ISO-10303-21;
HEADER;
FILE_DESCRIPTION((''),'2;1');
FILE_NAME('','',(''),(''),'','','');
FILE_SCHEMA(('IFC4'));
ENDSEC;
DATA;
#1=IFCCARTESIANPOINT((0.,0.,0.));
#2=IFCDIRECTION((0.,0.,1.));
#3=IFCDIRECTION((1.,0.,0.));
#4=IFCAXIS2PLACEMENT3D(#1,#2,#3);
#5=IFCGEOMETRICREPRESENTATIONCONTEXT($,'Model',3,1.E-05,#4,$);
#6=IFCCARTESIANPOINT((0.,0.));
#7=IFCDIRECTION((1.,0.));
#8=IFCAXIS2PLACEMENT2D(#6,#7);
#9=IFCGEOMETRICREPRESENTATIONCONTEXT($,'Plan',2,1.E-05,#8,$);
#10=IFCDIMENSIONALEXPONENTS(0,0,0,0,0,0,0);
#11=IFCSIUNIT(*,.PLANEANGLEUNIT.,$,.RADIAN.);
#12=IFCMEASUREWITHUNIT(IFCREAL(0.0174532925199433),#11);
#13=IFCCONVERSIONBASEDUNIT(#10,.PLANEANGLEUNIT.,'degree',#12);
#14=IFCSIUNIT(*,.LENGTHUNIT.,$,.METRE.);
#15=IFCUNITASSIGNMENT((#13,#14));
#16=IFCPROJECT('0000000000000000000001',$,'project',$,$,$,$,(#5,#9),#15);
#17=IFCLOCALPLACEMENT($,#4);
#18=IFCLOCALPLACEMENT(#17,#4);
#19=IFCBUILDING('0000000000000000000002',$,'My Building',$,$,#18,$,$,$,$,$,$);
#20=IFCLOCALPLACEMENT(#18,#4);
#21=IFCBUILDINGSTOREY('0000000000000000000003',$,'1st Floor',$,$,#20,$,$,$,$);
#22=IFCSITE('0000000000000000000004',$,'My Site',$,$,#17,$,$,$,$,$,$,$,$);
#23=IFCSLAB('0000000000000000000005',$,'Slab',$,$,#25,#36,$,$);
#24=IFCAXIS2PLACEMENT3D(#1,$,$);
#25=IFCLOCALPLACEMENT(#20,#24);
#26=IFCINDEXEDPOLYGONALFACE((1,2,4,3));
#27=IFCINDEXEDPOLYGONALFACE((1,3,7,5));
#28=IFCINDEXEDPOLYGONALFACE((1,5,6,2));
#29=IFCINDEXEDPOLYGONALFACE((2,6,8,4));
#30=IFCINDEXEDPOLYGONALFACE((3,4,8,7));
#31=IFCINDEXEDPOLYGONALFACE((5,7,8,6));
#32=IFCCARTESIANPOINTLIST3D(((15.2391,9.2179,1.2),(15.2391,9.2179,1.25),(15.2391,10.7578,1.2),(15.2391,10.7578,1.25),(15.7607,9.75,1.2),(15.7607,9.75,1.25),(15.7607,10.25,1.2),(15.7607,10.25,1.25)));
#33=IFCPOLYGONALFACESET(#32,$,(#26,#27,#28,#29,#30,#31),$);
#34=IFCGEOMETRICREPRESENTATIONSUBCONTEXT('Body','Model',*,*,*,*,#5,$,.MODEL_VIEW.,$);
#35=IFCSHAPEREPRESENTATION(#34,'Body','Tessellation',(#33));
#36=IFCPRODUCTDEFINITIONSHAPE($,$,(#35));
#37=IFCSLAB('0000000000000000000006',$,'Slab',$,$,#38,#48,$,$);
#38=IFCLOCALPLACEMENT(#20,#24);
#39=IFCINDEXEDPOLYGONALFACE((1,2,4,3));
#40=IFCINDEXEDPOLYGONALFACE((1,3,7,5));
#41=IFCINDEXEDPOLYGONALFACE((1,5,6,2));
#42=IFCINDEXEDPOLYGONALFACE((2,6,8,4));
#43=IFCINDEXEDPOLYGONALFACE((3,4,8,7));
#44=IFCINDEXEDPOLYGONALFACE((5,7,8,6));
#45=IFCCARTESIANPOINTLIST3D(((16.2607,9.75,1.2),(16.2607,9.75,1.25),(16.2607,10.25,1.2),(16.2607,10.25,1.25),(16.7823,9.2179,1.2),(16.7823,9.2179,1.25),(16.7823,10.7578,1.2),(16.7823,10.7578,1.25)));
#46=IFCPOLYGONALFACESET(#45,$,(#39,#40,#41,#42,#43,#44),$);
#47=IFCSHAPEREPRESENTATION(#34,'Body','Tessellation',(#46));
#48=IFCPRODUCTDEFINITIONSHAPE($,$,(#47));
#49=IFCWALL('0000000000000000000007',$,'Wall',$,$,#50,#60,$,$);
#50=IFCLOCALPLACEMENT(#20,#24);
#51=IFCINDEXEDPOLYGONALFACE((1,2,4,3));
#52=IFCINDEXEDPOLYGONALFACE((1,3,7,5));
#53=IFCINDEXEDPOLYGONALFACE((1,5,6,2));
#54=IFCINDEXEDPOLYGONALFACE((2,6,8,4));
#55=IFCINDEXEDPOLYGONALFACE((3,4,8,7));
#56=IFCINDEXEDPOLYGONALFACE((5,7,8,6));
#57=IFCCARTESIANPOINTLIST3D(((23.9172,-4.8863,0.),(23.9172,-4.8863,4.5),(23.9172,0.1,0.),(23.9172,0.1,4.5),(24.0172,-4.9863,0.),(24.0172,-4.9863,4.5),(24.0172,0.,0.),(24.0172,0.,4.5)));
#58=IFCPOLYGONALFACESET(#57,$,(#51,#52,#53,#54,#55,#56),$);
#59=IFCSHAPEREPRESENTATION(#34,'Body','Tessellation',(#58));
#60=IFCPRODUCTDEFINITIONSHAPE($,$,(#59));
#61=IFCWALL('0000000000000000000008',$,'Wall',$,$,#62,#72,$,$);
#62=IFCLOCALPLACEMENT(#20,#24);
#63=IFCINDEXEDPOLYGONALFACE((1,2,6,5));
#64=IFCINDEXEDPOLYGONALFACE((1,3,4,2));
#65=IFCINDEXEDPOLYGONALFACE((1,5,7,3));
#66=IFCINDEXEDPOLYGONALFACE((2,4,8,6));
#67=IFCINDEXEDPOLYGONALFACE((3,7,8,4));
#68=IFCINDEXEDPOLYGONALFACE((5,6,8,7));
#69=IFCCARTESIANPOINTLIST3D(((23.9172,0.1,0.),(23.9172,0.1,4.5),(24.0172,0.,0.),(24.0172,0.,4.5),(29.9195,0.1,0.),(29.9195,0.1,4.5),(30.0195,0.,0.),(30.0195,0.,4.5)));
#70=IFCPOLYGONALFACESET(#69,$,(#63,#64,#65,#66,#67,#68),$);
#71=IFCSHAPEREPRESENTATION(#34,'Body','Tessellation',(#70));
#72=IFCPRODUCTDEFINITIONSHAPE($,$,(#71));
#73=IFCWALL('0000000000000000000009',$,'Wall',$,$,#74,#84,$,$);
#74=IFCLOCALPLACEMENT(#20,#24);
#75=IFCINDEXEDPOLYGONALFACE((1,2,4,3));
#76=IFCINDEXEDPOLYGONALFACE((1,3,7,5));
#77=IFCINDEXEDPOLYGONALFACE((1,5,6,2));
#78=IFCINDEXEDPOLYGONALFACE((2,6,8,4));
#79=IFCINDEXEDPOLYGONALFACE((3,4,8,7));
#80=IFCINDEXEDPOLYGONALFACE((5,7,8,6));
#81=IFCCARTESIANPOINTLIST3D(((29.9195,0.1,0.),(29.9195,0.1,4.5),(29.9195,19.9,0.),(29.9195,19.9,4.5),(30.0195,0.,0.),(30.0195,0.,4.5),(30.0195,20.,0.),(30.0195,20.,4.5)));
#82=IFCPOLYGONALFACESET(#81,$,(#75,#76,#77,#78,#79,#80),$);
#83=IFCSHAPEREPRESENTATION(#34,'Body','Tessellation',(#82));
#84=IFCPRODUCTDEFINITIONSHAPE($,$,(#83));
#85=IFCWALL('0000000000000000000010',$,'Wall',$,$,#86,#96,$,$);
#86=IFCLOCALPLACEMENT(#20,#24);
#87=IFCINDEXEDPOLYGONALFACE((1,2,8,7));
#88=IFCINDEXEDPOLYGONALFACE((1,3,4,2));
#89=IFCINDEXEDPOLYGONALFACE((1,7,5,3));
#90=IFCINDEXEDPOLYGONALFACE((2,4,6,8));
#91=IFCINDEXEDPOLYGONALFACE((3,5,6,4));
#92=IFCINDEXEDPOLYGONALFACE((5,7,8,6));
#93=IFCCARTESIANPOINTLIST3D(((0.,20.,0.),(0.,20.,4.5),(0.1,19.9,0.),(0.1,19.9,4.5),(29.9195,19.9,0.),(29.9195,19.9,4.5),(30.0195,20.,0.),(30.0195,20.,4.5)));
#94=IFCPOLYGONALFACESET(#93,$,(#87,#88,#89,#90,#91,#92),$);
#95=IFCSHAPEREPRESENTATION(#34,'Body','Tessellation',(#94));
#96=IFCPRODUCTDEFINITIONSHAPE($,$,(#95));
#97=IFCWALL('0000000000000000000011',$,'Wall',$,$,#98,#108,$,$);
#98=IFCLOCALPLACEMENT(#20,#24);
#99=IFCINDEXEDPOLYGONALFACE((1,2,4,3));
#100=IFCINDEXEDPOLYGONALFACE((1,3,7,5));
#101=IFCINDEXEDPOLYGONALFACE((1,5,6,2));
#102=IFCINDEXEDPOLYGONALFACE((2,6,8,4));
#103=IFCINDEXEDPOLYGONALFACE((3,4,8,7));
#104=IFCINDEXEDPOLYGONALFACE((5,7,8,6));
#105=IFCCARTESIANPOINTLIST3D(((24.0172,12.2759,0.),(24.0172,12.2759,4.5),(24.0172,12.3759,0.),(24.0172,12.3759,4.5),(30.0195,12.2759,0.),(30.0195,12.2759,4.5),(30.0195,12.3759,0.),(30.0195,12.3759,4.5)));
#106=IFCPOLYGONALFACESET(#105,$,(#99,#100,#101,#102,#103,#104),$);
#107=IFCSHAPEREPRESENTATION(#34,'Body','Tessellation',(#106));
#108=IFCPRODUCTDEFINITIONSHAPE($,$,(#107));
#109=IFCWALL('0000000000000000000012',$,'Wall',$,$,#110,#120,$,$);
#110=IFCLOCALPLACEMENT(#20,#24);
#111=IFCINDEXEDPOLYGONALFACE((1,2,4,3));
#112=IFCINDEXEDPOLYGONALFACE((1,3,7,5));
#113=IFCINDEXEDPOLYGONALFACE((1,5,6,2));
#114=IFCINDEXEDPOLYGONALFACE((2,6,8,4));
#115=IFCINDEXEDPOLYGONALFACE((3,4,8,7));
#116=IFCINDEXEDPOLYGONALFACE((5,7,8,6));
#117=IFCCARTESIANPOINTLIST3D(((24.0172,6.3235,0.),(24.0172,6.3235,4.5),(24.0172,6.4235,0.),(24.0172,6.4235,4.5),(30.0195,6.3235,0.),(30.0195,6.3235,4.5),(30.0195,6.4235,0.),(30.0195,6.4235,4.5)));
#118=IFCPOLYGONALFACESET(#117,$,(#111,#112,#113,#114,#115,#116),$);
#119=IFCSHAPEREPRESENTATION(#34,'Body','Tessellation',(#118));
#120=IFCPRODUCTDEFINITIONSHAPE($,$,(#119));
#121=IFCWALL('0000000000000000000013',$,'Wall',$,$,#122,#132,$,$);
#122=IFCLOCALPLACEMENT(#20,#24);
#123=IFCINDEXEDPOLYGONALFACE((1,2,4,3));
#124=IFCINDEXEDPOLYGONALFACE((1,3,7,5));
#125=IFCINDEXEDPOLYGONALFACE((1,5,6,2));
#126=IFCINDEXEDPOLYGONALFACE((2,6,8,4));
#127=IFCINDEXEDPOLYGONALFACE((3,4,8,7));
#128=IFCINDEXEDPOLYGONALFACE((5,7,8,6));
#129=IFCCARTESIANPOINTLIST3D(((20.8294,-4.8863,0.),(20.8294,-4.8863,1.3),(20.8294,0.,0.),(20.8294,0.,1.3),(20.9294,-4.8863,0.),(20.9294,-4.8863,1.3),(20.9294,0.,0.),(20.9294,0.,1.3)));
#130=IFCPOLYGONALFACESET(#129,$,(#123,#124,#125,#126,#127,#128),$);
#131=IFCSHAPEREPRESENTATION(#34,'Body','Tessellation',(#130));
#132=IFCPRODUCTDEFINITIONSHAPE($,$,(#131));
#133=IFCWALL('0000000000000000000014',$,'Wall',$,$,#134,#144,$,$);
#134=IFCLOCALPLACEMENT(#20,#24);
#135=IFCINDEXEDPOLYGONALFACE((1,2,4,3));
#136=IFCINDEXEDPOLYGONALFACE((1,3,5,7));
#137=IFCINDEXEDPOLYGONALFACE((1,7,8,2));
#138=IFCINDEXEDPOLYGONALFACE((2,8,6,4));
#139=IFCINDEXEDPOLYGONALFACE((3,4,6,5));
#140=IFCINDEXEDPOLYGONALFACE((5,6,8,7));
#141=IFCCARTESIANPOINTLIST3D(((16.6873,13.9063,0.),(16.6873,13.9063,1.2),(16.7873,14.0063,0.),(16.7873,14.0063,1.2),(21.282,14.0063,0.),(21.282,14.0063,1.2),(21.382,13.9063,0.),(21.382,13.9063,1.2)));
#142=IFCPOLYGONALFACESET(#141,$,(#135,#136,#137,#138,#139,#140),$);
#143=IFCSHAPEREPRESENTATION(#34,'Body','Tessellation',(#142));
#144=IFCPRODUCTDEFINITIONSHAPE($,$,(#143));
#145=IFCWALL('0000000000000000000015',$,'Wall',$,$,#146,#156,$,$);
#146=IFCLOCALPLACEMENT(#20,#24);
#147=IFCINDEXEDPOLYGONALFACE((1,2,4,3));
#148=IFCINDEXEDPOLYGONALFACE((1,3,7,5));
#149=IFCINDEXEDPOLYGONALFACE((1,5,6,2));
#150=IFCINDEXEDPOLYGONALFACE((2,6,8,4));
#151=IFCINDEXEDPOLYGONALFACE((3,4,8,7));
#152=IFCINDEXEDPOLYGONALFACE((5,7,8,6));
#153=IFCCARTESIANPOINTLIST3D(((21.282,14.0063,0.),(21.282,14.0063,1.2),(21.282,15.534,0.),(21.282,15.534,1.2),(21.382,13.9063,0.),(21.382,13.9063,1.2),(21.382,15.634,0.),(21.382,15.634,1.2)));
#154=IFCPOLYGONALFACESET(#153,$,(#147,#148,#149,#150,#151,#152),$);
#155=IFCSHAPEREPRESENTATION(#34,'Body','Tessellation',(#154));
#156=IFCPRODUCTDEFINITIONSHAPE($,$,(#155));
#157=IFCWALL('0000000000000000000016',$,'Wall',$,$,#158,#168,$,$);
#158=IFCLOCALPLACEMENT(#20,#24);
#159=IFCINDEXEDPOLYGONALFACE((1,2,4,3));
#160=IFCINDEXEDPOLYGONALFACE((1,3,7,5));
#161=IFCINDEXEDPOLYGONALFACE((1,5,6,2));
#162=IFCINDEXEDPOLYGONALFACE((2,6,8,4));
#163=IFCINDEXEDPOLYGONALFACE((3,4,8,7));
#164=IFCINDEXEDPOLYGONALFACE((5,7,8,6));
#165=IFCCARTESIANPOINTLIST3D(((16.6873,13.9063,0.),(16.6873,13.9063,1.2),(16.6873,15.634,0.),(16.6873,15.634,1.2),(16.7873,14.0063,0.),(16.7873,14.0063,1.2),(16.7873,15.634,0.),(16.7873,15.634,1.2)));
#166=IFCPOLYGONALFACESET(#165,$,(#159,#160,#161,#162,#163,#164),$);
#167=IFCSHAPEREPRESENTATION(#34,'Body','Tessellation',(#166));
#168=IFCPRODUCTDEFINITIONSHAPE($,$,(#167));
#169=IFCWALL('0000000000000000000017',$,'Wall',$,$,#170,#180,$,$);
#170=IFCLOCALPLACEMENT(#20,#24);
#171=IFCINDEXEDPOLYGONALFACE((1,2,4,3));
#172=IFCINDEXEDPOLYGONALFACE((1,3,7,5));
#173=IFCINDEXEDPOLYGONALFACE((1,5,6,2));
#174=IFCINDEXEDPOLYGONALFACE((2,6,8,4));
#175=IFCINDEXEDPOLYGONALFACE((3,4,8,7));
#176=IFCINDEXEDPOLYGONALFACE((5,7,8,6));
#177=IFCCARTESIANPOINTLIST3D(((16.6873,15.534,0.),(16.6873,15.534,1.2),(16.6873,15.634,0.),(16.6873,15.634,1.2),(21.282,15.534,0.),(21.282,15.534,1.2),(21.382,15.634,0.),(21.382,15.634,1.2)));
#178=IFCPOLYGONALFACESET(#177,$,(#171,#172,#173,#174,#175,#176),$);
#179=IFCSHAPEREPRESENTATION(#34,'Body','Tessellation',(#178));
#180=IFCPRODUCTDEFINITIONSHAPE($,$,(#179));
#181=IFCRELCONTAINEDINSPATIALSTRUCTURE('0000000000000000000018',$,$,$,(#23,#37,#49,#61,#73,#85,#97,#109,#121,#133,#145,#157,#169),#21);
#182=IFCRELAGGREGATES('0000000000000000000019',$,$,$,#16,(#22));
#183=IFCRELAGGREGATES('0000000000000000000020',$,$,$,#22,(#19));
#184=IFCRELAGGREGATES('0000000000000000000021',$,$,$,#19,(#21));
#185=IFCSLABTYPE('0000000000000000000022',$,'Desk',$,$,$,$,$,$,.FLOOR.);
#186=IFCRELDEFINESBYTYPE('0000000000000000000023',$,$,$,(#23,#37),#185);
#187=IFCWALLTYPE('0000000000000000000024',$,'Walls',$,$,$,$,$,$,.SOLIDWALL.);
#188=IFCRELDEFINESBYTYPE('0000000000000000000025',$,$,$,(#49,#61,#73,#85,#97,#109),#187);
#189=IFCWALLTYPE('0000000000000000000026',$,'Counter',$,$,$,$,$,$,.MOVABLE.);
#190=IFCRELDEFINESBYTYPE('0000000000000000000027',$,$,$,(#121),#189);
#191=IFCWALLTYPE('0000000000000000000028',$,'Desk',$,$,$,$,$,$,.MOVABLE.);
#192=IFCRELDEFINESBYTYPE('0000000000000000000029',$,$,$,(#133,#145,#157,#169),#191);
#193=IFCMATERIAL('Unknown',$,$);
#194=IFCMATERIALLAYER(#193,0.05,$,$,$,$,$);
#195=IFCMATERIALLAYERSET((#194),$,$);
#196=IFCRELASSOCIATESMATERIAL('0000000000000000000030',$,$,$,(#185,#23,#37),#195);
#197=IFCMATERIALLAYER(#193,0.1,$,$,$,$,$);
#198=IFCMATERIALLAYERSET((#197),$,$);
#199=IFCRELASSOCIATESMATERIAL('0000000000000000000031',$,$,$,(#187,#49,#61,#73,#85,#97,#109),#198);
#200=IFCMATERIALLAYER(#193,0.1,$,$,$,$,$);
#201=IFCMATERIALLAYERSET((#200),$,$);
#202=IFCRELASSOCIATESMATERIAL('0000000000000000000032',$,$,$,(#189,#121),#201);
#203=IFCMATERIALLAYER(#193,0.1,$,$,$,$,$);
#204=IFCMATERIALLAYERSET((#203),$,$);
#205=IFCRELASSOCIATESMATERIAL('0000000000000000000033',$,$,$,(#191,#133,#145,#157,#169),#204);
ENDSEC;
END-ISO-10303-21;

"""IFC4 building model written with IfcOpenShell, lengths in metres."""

from ifc_helpers import new_model, entity, si_unit, converted_unit, frame, origin_with_axes, origin_2d_with_axis, place, context, subcontext, project, spatial, line, indexed_curve, outline, extrude, material, layer, layer_set, layer_usage, type_object, element, save


model = new_model("IFC4")

# Units and contexts
model_context = context("Model", 3, precision=1e-05, world=origin_with_axes())
plan_context = context("Plan", 2, precision=1e-05, world=origin_2d_with_axis())
body_context_1 = subcontext(model_context, "Body", "Model", "MODEL_VIEW")
ifc_project = project(units=[converted_unit("PLANEANGLEUNIT", "degree", entity("IfcReal", 0.0174532925199433), si_unit("PLANEANGLEUNIT", "RADIAN"), dimensions=[0, 0, 0, 0, 0, 0, 0]), si_unit("LENGTHUNIT", "METRE")], contexts=[model_context, plan_context])

# Site, building, storey
site_placement = place(None, origin_with_axes())
site = spatial("IfcSite", under=ifc_project, at=site_placement, Name="My Site")
building_placement = place(site_placement, origin_with_axes())
building = spatial("IfcBuilding", under=site, at=building_placement, Name="My Building")
storey_placement = place(building_placement, origin_with_axes())
storey = spatial("IfcBuildingStorey", under=building, at=storey_placement, Name="1st Floor")

# Shared definitions
ifc_material = material(Name="Unknown")

# Slabs
ifc_layer_1 = layer(ifc_material, 0.05)
ifc_layer_set_1 = layer_set([ifc_layer_1])
slab_type_1 = type_object("IfcSlabType", Name="Desk", PredefinedType="FLOOR", material=ifc_layer_set_1)
ifc_layer_usage_1 = layer_usage(ifc_layer_set_1, "AXIS3", "POSITIVE", -0.05)
slab_1_placement = place(storey_placement, frame((15.7607, 10.25, 1.25), z_axis=(0.0, 0.0, 1.0), x_axis=(1.0, 0.0, 0.0)))
element("IfcSlab", 1, at=slab_1_placement, inside=storey, type_object=slab_type_1, material=ifc_layer_usage_1, Name="Slab", context=body_context_1, shape_type="SweptSolid", body=[
    extrude(outline(indexed_curve([(0.0, 0.0), (-0.5216, 0.5078), (-0.5216, -1.0321), (0.0, -0.5), (0.0, 0.0)])), frame((0.0, 0.0, -0.05), z_axis=(0.0, 0.0, 1.0), x_axis=(1.0, 0.0, 0.0)), (0.0, 0.0, 1.0), 0.05),
])
ifc_layer_usage_2 = layer_usage(ifc_layer_set_1, "AXIS3", "POSITIVE", -0.05)
slab_2_placement = place(storey_placement, frame((16.7823, 10.7578, 1.25), z_axis=(0.0, 0.0, 1.0), x_axis=(1.0, 0.0, 0.0)))
element("IfcSlab", 2, at=slab_2_placement, inside=storey, type_object=slab_type_1, material=ifc_layer_usage_2, Name="Slab", context=body_context_1, shape_type="SweptSolid", body=[
    extrude(outline(indexed_curve([(0.0, 0.0), (-0.5216, -0.5078), (-0.5216, -1.0078), (0.0, -1.5399), (0.0, 0.0)])), frame((0.0, 0.0, -0.05), z_axis=(0.0, 0.0, 1.0), x_axis=(1.0, 0.0, 0.0)), (0.0, 0.0, 1.0), 0.05),
])

# Walls
ifc_layer_2 = layer(ifc_material, 0.1)
ifc_layer_set_2 = layer_set([ifc_layer_2])
ifc_layer_usage_3 = layer_usage(ifc_layer_set_2, "AXIS2", "POSITIVE", 0.0)
wall_type_1 = type_object("IfcWallType", Name="Walls", PredefinedType="SOLIDWALL", material=ifc_layer_set_2)
wall_1_placement = place(storey_placement, frame((24.0172, -4.9863, 0.0), z_axis=(0.0, 0.0, 1.0), x_axis=(0.0, 1.0, 0.0)))
element("IfcWall", 3, at=wall_1_placement, inside=storey, type_object=wall_type_1, material=ifc_layer_usage_3, Name="Wall", context=body_context_1, shape_type="SweptSolid", body=[
    extrude(outline(indexed_curve([(0.0, 0.0), (0.1, 0.1), (5.0863, 0.1), (4.9863, 0.0)], segments=[line(1, 2, 3, 4, 1)])), origin_with_axes(), (0.0, 0.0, 1.0), 4.5),
])
ifc_layer_usage_4 = layer_usage(ifc_layer_set_2, "AXIS2", "POSITIVE", 0.0)
wall_2_placement = place(storey_placement, frame((24.0172, 0.0, 0.0), z_axis=(0.0, 0.0, 1.0), x_axis=(1.0, 0.0, 0.0)))
element("IfcWall", 4, at=wall_2_placement, inside=storey, type_object=wall_type_1, material=ifc_layer_usage_4, Name="Wall", context=body_context_1, shape_type="SweptSolid", body=[
    extrude(outline(indexed_curve([(0.0, 0.0), (-0.1, 0.1), (5.9023, 0.1), (6.0023, 0.0)], segments=[line(1, 2, 3, 4, 1)])), origin_with_axes(), (0.0, 0.0, 1.0), 4.5),
])
ifc_layer_usage_5 = layer_usage(ifc_layer_set_2, "AXIS2", "POSITIVE", 0.0)
wall_3_placement = place(storey_placement, frame((30.0195, 0.0, 0.0), z_axis=(0.0, 0.0, 1.0), x_axis=(0.0, 1.0, 0.0)))
element("IfcWall", 5, at=wall_3_placement, inside=storey, type_object=wall_type_1, material=ifc_layer_usage_5, Name="Wall", context=body_context_1, shape_type="SweptSolid", body=[
    extrude(outline(indexed_curve([(0.0, 0.0), (0.1, 0.1), (19.9, 0.1), (20.0, 0.0)], segments=[line(1, 2, 3, 4, 1)])), origin_with_axes(), (0.0, 0.0, 1.0), 4.5),
])
ifc_layer_usage_6 = layer_usage(ifc_layer_set_2, "AXIS2", "POSITIVE", 0.0)
wall_4_placement = place(storey_placement, frame((30.0195, 20.0, 0.0), z_axis=(0.0, 0.0, 1.0), x_axis=(-1.0, 0.0, 0.0)))
element("IfcWall", 6, at=wall_4_placement, inside=storey, type_object=wall_type_1, material=ifc_layer_usage_6, Name="Wall", context=body_context_1, shape_type="SweptSolid", body=[
    extrude(outline(indexed_curve([(0.0, 0.0), (0.1, 0.1), (29.9195, 0.1), (30.0195, 0.0)], segments=[line(1, 2, 3, 4, 1)])), origin_with_axes(), (0.0, 0.0, 1.0), 4.5),
])

# Walls
ifc_layer_usage_7 = layer_usage(ifc_layer_set_2, "AXIS2", "POSITIVE", 0.0)
wall_5_placement = place(storey_placement, frame((24.0172, 12.2759, 0.0), z_axis=(0.0, 0.0, 1.0), x_axis=(1.0, 0.0, 0.0)))
element("IfcWall", 7, at=wall_5_placement, inside=storey, type_object=wall_type_1, material=ifc_layer_usage_7, Name="Wall", context=body_context_1, shape_type="SweptSolid", body=[
    extrude(outline(indexed_curve([(0.0, 0.0), (0.0, 0.1), (6.0024, 0.1), (6.0024, 0.0)], segments=[line(1, 2, 3, 4, 1)])), origin_with_axes(), (0.0, 0.0, 1.0), 4.5),
])
ifc_layer_usage_8 = layer_usage(ifc_layer_set_2, "AXIS2", "POSITIVE", 0.0)
wall_6_placement = place(storey_placement, frame((24.0172, 6.3235, 0.0), z_axis=(0.0, 0.0, 1.0), x_axis=(1.0, 0.0, 0.0)))
element("IfcWall", 8, at=wall_6_placement, inside=storey, type_object=wall_type_1, material=ifc_layer_usage_8, Name="Wall", context=body_context_1, shape_type="SweptSolid", body=[
    extrude(outline(indexed_curve([(0.0, 0.0), (0.0, 0.1), (6.0023, 0.1), (6.0023, 0.0)], segments=[line(1, 2, 3, 4, 1)])), origin_with_axes(), (0.0, 0.0, 1.0), 4.5),
])
ifc_layer_3 = layer(ifc_material, 0.1)
ifc_layer_set_3 = layer_set([ifc_layer_3])
ifc_layer_usage_9 = layer_usage(ifc_layer_set_3, "AXIS2", "POSITIVE", 0.0)
wall_type_2 = type_object("IfcWallType", Name="Counter", PredefinedType="MOVABLE", material=ifc_layer_set_3)
wall_7_placement = place(storey_placement, frame((20.8294, 0.0, 0.0), z_axis=(0.0, 0.0, 1.0), x_axis=(0.0, -1.0, 0.0)))
element("IfcWall", 9, at=wall_7_placement, inside=storey, type_object=wall_type_2, material=ifc_layer_usage_9, Name="Wall", context=body_context_1, shape_type="SweptSolid", body=[
    extrude(outline(indexed_curve([(0.0, 0.0), (0.0, 0.1), (4.8863, 0.1), (4.8863, 0.0)], segments=[line(1, 2, 3, 4, 1)])), origin_with_axes(), (0.0, 0.0, 1.0), 1.3),
])
ifc_layer_4 = layer(ifc_material, 0.1)
ifc_layer_set_4 = layer_set([ifc_layer_4])
ifc_layer_usage_10 = layer_usage(ifc_layer_set_4, "AXIS2", "POSITIVE", 0.0)
wall_type_3 = type_object("IfcWallType", Name="Desk", PredefinedType="MOVABLE", material=ifc_layer_set_4)
wall_8_placement = place(storey_placement, frame((16.6873, 13.9063, 0.0), z_axis=(0.0, 0.0, 1.0), x_axis=(1.0, 0.000001, 0.0)))
element("IfcWall", 10, at=wall_8_placement, inside=storey, type_object=wall_type_3, material=ifc_layer_usage_10, Name="Wall", context=body_context_1, shape_type="SweptSolid", body=[
    extrude(outline(indexed_curve([(0.0, 0.0), (0.1, 0.1), (4.5947, 0.1), (4.6947, 0.0)], segments=[line(1, 2, 3, 4, 1)])), origin_with_axes(), (0.0, 0.0, 1.0), 1.2),
])
ifc_layer_usage_11 = layer_usage(ifc_layer_set_4, "AXIS2", "POSITIVE", 0.0)
wall_9_placement = place(storey_placement, frame((21.382, 13.9063, 0.0), z_axis=(0.0, 0.0, 1.0), x_axis=(0.0, 1.0, 0.0)))
element("IfcWall", 11, at=wall_9_placement, inside=storey, type_object=wall_type_3, material=ifc_layer_usage_11, Name="Wall", context=body_context_1, shape_type="SweptSolid", body=[
    extrude(outline(indexed_curve([(0.0, 0.0), (0.1, 0.1), (1.6277, 0.1), (1.7277, 0.0)], segments=[line(1, 2, 3, 4, 1)])), origin_with_axes(), (0.0, 0.0, 1.0), 1.2),
])
ifc_layer_usage_12 = layer_usage(ifc_layer_set_4, "AXIS2", "POSITIVE", 0.0)
wall_10_placement = place(storey_placement, frame((16.6873, 15.634, 0.0), z_axis=(0.0, 0.0, 1.0), x_axis=(0.000001, -1.0, 0.0)))
element("IfcWall", 12, at=wall_10_placement, inside=storey, type_object=wall_type_3, material=ifc_layer_usage_12, Name="Wall", context=body_context_1, shape_type="SweptSolid", body=[
    extrude(outline(indexed_curve([(0.0, 0.0), (0.0, 0.1), (1.6277, 0.1), (1.7277, 0.0)], segments=[line(1, 2, 3, 4, 1)])), origin_with_axes(), (0.0, 0.0, 1.0), 1.2),
])
ifc_layer_usage_13 = layer_usage(ifc_layer_set_4, "AXIS2", "POSITIVE", 0.0)
wall_11_placement = place(storey_placement, frame((21.382, 15.634, 0.0), z_axis=(0.0, 0.0, 1.0), x_axis=(-1.0, -0.000001, 0.0)))
element("IfcWall", 13, at=wall_11_placement, inside=storey, type_object=wall_type_3, material=ifc_layer_usage_13, Name="Wall", context=body_context_1, shape_type="SweptSolid", body=[
    extrude(outline(indexed_curve([(0.0, 0.0), (0.1, 0.1), (4.6947, 0.1), (4.6947, 0.0)], segments=[line(1, 2, 3, 4, 1)])), origin_with_axes(), (0.0, 0.0, 1.0), 1.2),
])

save(model, "model.ifc")
